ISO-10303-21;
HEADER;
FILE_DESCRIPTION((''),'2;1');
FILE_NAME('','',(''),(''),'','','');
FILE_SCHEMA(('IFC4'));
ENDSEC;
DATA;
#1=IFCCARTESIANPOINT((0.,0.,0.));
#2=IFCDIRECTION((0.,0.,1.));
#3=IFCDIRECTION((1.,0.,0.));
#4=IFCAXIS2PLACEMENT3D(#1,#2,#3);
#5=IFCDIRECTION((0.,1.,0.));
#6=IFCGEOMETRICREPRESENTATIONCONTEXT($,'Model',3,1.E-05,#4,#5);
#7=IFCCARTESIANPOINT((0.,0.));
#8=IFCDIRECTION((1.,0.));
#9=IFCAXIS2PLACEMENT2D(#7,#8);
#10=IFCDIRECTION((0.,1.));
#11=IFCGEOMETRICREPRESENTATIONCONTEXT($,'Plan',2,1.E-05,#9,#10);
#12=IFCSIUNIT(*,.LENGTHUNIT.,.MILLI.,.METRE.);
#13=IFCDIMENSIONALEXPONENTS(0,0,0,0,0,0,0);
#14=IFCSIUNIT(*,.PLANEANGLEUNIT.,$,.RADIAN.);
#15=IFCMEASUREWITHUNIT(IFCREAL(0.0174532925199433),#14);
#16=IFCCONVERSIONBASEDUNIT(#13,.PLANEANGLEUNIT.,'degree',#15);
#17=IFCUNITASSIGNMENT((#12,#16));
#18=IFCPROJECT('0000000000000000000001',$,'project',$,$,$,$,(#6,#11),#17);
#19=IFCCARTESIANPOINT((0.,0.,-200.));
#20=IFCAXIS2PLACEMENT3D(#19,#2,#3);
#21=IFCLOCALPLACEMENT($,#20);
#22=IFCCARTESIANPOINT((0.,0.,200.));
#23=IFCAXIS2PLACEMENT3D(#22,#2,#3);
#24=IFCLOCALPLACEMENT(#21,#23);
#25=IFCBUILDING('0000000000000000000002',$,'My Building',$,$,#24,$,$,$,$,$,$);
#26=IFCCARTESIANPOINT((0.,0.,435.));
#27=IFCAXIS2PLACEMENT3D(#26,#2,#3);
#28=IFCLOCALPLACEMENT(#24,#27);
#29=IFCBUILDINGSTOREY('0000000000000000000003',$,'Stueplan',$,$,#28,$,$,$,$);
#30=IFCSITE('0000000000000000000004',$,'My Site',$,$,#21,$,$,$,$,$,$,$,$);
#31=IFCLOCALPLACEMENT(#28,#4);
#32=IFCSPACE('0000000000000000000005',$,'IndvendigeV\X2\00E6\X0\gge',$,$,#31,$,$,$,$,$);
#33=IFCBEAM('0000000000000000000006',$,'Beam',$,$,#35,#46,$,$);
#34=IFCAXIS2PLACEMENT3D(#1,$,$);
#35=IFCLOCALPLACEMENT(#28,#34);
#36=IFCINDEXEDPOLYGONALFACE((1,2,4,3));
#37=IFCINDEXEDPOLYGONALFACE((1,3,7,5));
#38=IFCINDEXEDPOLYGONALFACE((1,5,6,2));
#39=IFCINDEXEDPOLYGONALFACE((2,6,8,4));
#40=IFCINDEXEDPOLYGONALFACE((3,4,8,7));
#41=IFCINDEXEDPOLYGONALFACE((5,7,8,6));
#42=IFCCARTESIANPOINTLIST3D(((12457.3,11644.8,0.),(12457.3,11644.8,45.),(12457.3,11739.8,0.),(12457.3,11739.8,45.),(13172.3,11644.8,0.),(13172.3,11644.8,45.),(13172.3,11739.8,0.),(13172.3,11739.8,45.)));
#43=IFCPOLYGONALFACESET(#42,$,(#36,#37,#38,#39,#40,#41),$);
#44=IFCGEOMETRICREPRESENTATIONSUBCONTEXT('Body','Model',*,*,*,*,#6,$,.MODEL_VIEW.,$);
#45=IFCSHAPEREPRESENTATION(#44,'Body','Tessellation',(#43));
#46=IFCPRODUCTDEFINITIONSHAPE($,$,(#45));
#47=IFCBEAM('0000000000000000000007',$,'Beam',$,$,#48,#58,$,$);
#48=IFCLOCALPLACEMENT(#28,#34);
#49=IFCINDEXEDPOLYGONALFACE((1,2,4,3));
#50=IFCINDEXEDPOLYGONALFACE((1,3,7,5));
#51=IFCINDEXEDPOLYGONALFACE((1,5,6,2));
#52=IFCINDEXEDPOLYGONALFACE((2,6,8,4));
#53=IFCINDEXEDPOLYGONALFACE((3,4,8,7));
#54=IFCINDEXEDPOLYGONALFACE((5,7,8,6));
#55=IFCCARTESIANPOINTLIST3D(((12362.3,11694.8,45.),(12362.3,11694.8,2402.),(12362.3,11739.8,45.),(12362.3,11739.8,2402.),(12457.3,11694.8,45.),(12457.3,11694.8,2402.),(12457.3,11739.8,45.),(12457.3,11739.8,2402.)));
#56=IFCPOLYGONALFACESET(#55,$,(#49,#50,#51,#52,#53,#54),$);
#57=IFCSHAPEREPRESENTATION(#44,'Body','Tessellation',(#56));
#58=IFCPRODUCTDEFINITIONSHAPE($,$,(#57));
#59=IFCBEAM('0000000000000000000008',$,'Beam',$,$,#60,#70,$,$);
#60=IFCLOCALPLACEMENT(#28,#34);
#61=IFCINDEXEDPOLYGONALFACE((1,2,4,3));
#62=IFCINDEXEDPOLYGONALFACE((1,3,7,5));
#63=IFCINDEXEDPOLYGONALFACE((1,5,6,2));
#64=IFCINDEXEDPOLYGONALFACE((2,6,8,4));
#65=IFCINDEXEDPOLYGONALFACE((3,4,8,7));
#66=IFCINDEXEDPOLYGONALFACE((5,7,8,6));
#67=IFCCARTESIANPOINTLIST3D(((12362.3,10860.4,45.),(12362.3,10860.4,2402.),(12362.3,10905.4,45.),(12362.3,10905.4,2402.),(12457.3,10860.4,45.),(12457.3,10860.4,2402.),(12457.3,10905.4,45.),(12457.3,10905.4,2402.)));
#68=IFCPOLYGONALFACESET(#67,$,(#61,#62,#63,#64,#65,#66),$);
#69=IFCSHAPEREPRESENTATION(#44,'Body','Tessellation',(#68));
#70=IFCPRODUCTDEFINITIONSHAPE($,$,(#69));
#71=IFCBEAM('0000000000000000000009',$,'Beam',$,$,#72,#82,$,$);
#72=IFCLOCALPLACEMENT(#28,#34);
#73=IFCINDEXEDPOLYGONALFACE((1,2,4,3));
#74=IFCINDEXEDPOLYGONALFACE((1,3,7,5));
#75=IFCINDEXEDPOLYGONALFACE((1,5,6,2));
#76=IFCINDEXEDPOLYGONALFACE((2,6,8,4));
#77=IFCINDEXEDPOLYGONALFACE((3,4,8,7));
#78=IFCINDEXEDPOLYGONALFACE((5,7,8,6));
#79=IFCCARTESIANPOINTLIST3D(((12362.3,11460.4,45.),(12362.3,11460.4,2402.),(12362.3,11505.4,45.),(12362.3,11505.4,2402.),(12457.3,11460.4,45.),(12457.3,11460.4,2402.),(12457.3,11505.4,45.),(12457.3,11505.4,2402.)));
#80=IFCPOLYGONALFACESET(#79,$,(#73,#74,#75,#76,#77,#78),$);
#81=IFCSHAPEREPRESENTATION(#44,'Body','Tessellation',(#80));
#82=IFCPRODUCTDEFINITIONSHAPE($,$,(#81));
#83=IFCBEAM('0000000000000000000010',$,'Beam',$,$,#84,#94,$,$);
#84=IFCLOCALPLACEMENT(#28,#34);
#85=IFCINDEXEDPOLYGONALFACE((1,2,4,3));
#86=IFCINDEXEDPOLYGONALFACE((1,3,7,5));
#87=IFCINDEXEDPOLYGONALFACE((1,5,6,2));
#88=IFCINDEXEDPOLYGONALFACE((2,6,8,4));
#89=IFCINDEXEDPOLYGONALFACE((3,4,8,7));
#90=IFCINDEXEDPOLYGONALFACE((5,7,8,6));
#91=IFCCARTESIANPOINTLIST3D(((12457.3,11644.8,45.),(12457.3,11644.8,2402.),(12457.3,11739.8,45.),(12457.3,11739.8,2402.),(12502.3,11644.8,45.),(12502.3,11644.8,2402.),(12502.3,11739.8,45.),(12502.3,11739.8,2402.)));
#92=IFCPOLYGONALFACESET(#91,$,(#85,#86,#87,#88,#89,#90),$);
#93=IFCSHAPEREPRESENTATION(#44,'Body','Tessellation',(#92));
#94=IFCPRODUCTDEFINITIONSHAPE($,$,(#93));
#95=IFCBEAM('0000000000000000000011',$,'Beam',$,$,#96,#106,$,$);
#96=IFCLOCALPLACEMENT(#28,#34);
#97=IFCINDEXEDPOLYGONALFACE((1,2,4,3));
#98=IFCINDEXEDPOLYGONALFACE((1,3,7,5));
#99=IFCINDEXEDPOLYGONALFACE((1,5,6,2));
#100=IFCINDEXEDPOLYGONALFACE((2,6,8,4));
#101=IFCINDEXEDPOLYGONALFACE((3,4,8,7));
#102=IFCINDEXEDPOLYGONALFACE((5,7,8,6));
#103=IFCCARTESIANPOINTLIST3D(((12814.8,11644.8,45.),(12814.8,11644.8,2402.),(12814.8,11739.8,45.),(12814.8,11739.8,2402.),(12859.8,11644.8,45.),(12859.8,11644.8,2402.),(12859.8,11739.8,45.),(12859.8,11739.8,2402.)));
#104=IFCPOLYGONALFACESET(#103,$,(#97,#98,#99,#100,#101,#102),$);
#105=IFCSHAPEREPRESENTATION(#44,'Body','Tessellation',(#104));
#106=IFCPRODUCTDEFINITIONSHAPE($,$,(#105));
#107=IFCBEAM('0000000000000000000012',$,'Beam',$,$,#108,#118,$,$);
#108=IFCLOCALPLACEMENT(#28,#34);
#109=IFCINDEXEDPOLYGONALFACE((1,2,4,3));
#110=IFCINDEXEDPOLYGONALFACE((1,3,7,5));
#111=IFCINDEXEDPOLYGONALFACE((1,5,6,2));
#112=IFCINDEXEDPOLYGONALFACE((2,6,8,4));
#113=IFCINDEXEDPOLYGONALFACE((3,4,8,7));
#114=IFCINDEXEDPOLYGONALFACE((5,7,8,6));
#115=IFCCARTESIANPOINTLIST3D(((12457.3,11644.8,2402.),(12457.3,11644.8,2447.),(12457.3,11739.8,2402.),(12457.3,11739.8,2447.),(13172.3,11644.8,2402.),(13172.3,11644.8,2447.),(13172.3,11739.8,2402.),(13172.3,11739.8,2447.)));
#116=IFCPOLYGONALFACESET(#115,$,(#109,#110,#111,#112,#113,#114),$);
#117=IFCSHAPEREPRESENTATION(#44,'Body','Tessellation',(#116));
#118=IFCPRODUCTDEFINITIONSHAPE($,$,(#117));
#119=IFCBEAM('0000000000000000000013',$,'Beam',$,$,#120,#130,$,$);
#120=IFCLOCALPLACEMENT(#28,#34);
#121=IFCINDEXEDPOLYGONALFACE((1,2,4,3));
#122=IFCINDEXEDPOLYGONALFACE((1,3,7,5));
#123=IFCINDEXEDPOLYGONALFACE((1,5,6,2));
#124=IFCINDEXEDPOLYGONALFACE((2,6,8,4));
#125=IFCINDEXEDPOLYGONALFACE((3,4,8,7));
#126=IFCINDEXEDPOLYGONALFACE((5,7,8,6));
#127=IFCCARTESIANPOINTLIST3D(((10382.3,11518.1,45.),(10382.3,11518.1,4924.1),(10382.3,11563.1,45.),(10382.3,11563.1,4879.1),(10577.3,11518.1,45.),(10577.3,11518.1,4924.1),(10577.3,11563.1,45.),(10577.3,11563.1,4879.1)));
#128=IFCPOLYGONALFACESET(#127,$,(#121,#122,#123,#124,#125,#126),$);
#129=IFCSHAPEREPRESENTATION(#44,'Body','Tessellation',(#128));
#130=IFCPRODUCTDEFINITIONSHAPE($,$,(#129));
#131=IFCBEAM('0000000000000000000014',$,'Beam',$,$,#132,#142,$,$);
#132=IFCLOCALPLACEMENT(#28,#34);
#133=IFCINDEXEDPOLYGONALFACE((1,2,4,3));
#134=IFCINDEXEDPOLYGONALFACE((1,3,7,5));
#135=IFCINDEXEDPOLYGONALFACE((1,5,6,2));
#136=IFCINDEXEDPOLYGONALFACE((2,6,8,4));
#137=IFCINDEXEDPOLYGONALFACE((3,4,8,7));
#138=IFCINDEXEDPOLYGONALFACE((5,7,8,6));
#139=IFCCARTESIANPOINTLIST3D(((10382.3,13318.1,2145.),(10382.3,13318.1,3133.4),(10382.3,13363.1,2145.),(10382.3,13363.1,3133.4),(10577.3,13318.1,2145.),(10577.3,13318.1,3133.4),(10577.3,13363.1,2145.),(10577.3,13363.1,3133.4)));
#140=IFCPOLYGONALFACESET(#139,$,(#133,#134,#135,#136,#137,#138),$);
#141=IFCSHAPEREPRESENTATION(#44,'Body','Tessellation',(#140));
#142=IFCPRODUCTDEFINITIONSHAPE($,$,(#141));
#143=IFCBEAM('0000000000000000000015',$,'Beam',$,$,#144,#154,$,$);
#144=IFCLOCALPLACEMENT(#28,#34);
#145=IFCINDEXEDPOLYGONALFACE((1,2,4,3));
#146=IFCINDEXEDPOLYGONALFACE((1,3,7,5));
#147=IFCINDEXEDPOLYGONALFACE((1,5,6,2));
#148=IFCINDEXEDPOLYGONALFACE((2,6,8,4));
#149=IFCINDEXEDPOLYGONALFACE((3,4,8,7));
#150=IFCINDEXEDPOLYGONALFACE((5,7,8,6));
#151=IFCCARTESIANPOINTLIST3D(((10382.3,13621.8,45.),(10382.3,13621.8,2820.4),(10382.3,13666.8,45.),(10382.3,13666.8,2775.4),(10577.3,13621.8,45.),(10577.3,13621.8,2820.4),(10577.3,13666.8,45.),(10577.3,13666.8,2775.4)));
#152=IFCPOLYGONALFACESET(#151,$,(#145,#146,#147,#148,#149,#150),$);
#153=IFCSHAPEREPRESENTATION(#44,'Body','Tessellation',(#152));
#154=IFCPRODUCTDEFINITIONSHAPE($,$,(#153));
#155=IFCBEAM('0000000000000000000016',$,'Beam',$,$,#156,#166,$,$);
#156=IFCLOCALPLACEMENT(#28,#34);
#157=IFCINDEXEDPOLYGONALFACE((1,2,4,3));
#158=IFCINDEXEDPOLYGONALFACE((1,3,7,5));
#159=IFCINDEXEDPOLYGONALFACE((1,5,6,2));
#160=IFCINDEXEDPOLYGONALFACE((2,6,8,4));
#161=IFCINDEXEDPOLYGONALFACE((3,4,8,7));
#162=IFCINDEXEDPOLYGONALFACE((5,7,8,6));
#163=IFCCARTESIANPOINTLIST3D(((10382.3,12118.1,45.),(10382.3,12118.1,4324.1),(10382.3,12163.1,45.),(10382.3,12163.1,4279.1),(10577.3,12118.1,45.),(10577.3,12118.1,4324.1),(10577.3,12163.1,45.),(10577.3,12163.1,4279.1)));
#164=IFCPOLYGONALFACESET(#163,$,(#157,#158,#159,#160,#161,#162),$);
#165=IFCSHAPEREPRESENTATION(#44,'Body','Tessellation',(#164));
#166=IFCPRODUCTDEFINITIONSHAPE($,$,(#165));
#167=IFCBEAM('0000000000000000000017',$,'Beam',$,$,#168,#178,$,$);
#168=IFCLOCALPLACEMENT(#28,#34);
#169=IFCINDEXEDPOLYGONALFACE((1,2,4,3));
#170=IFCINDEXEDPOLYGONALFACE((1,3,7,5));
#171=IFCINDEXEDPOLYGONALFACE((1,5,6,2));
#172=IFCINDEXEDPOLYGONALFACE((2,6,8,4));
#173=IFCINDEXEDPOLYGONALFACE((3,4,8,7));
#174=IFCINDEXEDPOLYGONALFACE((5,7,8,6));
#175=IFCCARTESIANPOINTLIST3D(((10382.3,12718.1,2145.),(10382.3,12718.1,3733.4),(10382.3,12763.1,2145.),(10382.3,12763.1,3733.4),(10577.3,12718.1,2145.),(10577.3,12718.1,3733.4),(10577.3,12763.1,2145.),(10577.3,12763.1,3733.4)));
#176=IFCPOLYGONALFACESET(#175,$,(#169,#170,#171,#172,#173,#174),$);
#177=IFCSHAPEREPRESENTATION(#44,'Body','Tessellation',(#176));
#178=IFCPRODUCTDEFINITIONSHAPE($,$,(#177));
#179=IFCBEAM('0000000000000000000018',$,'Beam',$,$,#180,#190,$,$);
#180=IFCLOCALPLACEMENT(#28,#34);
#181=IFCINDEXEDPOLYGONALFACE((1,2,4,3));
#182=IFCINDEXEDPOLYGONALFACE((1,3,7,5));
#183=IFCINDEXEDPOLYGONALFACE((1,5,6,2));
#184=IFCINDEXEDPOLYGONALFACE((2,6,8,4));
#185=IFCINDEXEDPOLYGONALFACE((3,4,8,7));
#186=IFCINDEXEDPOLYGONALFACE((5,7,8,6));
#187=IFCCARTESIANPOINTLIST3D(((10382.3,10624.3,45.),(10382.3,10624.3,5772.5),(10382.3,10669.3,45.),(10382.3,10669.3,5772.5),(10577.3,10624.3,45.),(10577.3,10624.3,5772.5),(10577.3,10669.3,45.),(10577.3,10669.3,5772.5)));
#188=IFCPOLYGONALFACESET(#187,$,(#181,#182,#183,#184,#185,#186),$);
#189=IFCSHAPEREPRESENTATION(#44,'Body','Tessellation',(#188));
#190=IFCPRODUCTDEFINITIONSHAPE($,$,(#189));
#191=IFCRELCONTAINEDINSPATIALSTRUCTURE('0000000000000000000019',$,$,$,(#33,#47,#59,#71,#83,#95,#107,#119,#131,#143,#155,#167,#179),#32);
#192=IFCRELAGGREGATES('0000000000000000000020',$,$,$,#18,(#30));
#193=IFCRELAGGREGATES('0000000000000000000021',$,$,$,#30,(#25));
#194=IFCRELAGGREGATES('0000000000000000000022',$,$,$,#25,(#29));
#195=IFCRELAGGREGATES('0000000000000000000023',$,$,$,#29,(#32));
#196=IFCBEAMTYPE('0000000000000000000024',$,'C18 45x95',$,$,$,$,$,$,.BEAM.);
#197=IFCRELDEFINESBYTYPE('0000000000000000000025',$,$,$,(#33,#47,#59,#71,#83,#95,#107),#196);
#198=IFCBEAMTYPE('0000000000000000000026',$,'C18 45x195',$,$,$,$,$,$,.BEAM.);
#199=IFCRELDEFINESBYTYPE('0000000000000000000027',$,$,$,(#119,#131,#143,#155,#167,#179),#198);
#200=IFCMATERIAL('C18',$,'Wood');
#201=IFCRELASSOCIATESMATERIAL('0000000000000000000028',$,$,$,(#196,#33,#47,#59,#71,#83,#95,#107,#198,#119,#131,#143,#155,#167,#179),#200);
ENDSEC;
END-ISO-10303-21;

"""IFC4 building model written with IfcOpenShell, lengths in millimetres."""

from ifc_helpers import new_model, entity, si_unit, converted_unit, direction, frame, origin_with_axes, origin_2d_with_axis, place, context, subcontext, project, spatial, rectangle, extrude, clip, halfspace, material, material_profile, profile_set, profile_usage, type_object, element, save


model = new_model("IFC4")

# Units and contexts
model_context = context("Model", 3, precision=1e-05, world=origin_with_axes(), true_north=direction((0.0, 1.0, 0.0)))
plan_context = context("Plan", 2, precision=1e-05, world=origin_2d_with_axis(), true_north=direction((0.0, 1.0)))
body_context_1 = subcontext(model_context, "Body", "Model", "MODEL_VIEW")
ifc_project = project(units=[si_unit("LENGTHUNIT", "METRE", prefix="MILLI"), converted_unit("PLANEANGLEUNIT", "degree", entity("IfcReal", 0.0174532925199433), si_unit("PLANEANGLEUNIT", "RADIAN"), dimensions=[0, 0, 0, 0, 0, 0, 0])], contexts=[model_context, plan_context])

# Site, building, storey
site_placement = place(None, frame((0.0, 0.0, -200.0), z_axis=(0.0, 0.0, 1.0), x_axis=(1.0, 0.0, 0.0)))
site = spatial("IfcSite", under=ifc_project, at=site_placement, Name="My Site")
building_placement = place(site_placement, frame((0.0, 0.0, 200.0), z_axis=(0.0, 0.0, 1.0), x_axis=(1.0, 0.0, 0.0)))
building = spatial("IfcBuilding", under=site, at=building_placement, Name="My Building")
storey_placement = place(building_placement, frame((0.0, 0.0, 435.0), z_axis=(0.0, 0.0, 1.0), x_axis=(1.0, 0.0, 0.0)))
storey = spatial("IfcBuildingStorey", under=building, at=storey_placement, Name="Stueplan")

# Shared definitions
ifc_material = material(Name="C18", Category="Wood")

# Shared definitions
space_1_placement = place(storey_placement, frame((0.0, 0.0, 0.0), z_axis=(0.0, 0.0, 1.0), x_axis=(1.0, 0.0, 0.0)))
space_1 = spatial("IfcSpace", under=storey, at=space_1_placement, Name="IndvendigeVægge")

# Beams
ifc_material_profile_1 = material_profile(ifc_material, rectangle(XDim=45.0, YDim=95.0))
ifc_profile_set_1 = profile_set([ifc_material_profile_1], Name="woodStructural")
ifc_profile_usage_1 = profile_usage(ifc_profile_set_1, cardinal=5)
beam_type_1 = type_object("IfcBeamType", Name="C18 45x95", PredefinedType="BEAM", material=ifc_profile_set_1)
beam_1_placement = place(space_1_placement, frame((12457.3, 11692.3, 22.5), z_axis=(1.0, 0.0, 0.0), x_axis=(0.0, 0.0, 1.0)))
element("IfcBeam", 1, at=beam_1_placement, inside=space_1, type_object=beam_type_1, material=ifc_profile_usage_1, Name="Beam", context=body_context_1, shape_type="SweptSolid", body=[
    extrude(rectangle(XDim=45.0, YDim=95.0), origin_with_axes(), (0.0, 0.0, 1.0), 715.0),
])
ifc_profile_usage_2 = profile_usage(ifc_profile_set_1)
beam_2_placement = place(space_1_placement, frame((12409.8, 11717.3, 45.0), z_axis=(0.0, 0.0, 1.0), x_axis=(0.0, -1.0, 0.0)))
element("IfcBeam", 2, at=beam_2_placement, inside=space_1, type_object=beam_type_1, material=ifc_profile_usage_2, Name="Beam", context=body_context_1, shape_type="SweptSolid", body=[
    extrude(rectangle(XDim=45.0, YDim=95.0), origin_with_axes(), (0.0, 0.0, 1.0), 2357.0),
])
ifc_profile_usage_3 = profile_usage(ifc_profile_set_1)
beam_3_placement = place(space_1_placement, frame((12409.8, 10882.9, 45.0), z_axis=(0.0, 0.0, 1.0), x_axis=(0.0, -1.0, 0.0)))
element("IfcBeam", 3, at=beam_3_placement, inside=space_1, type_object=beam_type_1, material=ifc_profile_usage_3, Name="Beam", context=body_context_1, shape_type="SweptSolid", body=[
    extrude(rectangle(XDim=45.0, YDim=95.0), origin_with_axes(), (0.0, 0.0, 1.0), 2357.0),
])
ifc_profile_usage_4 = profile_usage(ifc_profile_set_1)
beam_4_placement = place(space_1_placement, frame((12409.8, 11482.9, 45.0), z_axis=(0.0, 0.0, 1.0), x_axis=(0.0, -1.0, 0.0)))
element("IfcBeam", 4, at=beam_4_placement, inside=space_1, type_object=beam_type_1, material=ifc_profile_usage_4, Name="Beam", context=body_context_1, shape_type="SweptSolid", body=[
    extrude(rectangle(XDim=45.0, YDim=95.0), origin_with_axes(), (0.0, 0.0, 1.0), 2357.0),
])
ifc_profile_usage_5 = profile_usage(ifc_profile_set_1)
beam_5_placement = place(space_1_placement, frame((12479.8, 11692.3, 45.0), z_axis=(0.0, 0.0, 1.0), x_axis=(1.0, 0.0, 0.0)))
element("IfcBeam", 5, at=beam_5_placement, inside=space_1, type_object=beam_type_1, material=ifc_profile_usage_5, Name="Beam", context=body_context_1, shape_type="SweptSolid", body=[
    extrude(rectangle(XDim=45.0, YDim=95.0), origin_with_axes(), (0.0, 0.0, 1.0), 2357.0),
])
ifc_profile_usage_6 = profile_usage(ifc_profile_set_1)
beam_6_placement = place(space_1_placement, frame((12837.3, 11692.3, 45.0), z_axis=(0.0, 0.0, 1.0), x_axis=(1.0, 0.0, 0.0)))
element("IfcBeam", 6, at=beam_6_placement, inside=space_1, type_object=beam_type_1, material=ifc_profile_usage_6, Name="Beam", context=body_context_1, shape_type="SweptSolid", body=[
    extrude(rectangle(XDim=45.0, YDim=95.0), origin_with_axes(), (0.0, 0.0, 1.0), 2357.0),
])
ifc_profile_usage_7 = profile_usage(ifc_profile_set_1, cardinal=5)
beam_7_placement = place(space_1_placement, frame((12457.3, 11692.3, 2424.5), z_axis=(1.0, 0.0, 0.0), x_axis=(0.0, 0.0, 1.0)))
element("IfcBeam", 7, at=beam_7_placement, inside=space_1, type_object=beam_type_1, material=ifc_profile_usage_7, Name="Beam", context=body_context_1, shape_type="SweptSolid", body=[
    extrude(rectangle(XDim=45.0, YDim=95.0), origin_with_axes(), (0.0, 0.0, 1.0), 715.0),
])
ifc_material_profile_2 = material_profile(ifc_material, rectangle(XDim=45.0, YDim=195.0))
ifc_profile_set_2 = profile_set([ifc_material_profile_2], Name="woodStructural")
ifc_profile_usage_8 = profile_usage(ifc_profile_set_2)
beam_type_2 = type_object("IfcBeamType", Name="C18 45x195", PredefinedType="BEAM", material=ifc_profile_set_2)
beam_8_placement = place(space_1_placement, frame((10479.8, 11540.6, 45.0), z_axis=(0.0, 0.0, 1.0), x_axis=(0.0, 1.0, 0.0)))
element("IfcBeam", 8, at=beam_8_placement, inside=space_1, type_object=beam_type_2, material=ifc_profile_usage_8, Name="Beam", context=body_context_1, shape_type="Clipping", body=[
    clip(extrude(rectangle(XDim=45.0, YDim=195.0), origin_with_axes(), (0.0, 0.0, 1.0), 5051.6), halfspace(frame((2248.2, 0.0, 2608.4), z_axis=(0.707107, 0.0, 0.707107), x_axis=(0.0, -1.0, 0.0)), False)),
])
ifc_profile_usage_9 = profile_usage(ifc_profile_set_2)
beam_9_placement = place(space_1_placement, frame((10479.8, 13340.6, 2145.0), z_axis=(0.0, 0.0, 1.0), x_axis=(0.0, 1.0, 0.0)))
element("IfcBeam", 9, at=beam_9_placement, inside=space_1, type_object=beam_type_2, material=ifc_profile_usage_9, Name="Beam", context=body_context_1, shape_type="SweptSolid", body=[
    extrude(rectangle(XDim=45.0, YDim=195.0), origin_with_axes(), (0.0, 0.0, 1.0), 988.4),
])
ifc_profile_usage_10 = profile_usage(ifc_profile_set_2)
beam_10_placement = place(space_1_placement, frame((10479.8, 13644.3, 45.0), z_axis=(0.0, 0.0, 1.0), x_axis=(0.0, 1.0, 0.0)))
element("IfcBeam", 10, at=beam_10_placement, inside=space_1, type_object=beam_type_2, material=ifc_profile_usage_10, Name="Beam", context=body_context_1, shape_type="Clipping", body=[
    clip(extrude(rectangle(XDim=45.0, YDim=195.0), origin_with_axes(), (0.0, 0.0, 1.0), 2947.9), halfspace(frame((144.5, 0.0, 2608.4), z_axis=(0.707107, 0.0, 0.707107), x_axis=(0.0, -1.0, 0.0)), False)),
])
ifc_profile_usage_11 = profile_usage(ifc_profile_set_2)
beam_11_placement = place(space_1_placement, frame((10479.8, 12140.6, 45.0), z_axis=(0.0, 0.0, 1.0), x_axis=(0.0, 1.0, 0.0)))
element("IfcBeam", 11, at=beam_11_placement, inside=space_1, type_object=beam_type_2, material=ifc_profile_usage_11, Name="Beam", context=body_context_1, shape_type="Clipping", body=[
    clip(extrude(rectangle(XDim=45.0, YDim=195.0), origin_with_axes(), (0.0, 0.0, 1.0), 4451.6), halfspace(frame((1648.2, 0.0, 2608.4), z_axis=(0.707107, 0.0, 0.707107), x_axis=(0.0, -1.0, 0.0)), False)),
])
ifc_profile_usage_12 = profile_usage(ifc_profile_set_2)
beam_12_placement = place(space_1_placement, frame((10479.8, 12740.6, 2145.0), z_axis=(0.0, 0.0, 1.0), x_axis=(0.0, 1.0, 0.0)))
element("IfcBeam", 12, at=beam_12_placement, inside=space_1, type_object=beam_type_2, material=ifc_profile_usage_12, Name="Beam", context=body_context_1, shape_type="SweptSolid", body=[
    extrude(rectangle(XDim=45.0, YDim=195.0), origin_with_axes(), (0.0, 0.0, 1.0), 1588.4),
])
ifc_profile_usage_13 = profile_usage(ifc_profile_set_2)
beam_13_placement = place(space_1_placement, frame((10479.8, 10646.8, 45.0), z_axis=(0.0, 0.0, 1.0), x_axis=(0.0, 1.0, 0.0)))
element("IfcBeam", 13, at=beam_13_placement, inside=space_1, type_object=beam_type_2, material=ifc_profile_usage_13, Name="Beam", context=body_context_1, shape_type="SweptSolid", body=[
    extrude(rectangle(XDim=45.0, YDim=195.0), origin_with_axes(), (0.0, 0.0, 1.0), 5727.5),
])

save(model, "model.ifc")
